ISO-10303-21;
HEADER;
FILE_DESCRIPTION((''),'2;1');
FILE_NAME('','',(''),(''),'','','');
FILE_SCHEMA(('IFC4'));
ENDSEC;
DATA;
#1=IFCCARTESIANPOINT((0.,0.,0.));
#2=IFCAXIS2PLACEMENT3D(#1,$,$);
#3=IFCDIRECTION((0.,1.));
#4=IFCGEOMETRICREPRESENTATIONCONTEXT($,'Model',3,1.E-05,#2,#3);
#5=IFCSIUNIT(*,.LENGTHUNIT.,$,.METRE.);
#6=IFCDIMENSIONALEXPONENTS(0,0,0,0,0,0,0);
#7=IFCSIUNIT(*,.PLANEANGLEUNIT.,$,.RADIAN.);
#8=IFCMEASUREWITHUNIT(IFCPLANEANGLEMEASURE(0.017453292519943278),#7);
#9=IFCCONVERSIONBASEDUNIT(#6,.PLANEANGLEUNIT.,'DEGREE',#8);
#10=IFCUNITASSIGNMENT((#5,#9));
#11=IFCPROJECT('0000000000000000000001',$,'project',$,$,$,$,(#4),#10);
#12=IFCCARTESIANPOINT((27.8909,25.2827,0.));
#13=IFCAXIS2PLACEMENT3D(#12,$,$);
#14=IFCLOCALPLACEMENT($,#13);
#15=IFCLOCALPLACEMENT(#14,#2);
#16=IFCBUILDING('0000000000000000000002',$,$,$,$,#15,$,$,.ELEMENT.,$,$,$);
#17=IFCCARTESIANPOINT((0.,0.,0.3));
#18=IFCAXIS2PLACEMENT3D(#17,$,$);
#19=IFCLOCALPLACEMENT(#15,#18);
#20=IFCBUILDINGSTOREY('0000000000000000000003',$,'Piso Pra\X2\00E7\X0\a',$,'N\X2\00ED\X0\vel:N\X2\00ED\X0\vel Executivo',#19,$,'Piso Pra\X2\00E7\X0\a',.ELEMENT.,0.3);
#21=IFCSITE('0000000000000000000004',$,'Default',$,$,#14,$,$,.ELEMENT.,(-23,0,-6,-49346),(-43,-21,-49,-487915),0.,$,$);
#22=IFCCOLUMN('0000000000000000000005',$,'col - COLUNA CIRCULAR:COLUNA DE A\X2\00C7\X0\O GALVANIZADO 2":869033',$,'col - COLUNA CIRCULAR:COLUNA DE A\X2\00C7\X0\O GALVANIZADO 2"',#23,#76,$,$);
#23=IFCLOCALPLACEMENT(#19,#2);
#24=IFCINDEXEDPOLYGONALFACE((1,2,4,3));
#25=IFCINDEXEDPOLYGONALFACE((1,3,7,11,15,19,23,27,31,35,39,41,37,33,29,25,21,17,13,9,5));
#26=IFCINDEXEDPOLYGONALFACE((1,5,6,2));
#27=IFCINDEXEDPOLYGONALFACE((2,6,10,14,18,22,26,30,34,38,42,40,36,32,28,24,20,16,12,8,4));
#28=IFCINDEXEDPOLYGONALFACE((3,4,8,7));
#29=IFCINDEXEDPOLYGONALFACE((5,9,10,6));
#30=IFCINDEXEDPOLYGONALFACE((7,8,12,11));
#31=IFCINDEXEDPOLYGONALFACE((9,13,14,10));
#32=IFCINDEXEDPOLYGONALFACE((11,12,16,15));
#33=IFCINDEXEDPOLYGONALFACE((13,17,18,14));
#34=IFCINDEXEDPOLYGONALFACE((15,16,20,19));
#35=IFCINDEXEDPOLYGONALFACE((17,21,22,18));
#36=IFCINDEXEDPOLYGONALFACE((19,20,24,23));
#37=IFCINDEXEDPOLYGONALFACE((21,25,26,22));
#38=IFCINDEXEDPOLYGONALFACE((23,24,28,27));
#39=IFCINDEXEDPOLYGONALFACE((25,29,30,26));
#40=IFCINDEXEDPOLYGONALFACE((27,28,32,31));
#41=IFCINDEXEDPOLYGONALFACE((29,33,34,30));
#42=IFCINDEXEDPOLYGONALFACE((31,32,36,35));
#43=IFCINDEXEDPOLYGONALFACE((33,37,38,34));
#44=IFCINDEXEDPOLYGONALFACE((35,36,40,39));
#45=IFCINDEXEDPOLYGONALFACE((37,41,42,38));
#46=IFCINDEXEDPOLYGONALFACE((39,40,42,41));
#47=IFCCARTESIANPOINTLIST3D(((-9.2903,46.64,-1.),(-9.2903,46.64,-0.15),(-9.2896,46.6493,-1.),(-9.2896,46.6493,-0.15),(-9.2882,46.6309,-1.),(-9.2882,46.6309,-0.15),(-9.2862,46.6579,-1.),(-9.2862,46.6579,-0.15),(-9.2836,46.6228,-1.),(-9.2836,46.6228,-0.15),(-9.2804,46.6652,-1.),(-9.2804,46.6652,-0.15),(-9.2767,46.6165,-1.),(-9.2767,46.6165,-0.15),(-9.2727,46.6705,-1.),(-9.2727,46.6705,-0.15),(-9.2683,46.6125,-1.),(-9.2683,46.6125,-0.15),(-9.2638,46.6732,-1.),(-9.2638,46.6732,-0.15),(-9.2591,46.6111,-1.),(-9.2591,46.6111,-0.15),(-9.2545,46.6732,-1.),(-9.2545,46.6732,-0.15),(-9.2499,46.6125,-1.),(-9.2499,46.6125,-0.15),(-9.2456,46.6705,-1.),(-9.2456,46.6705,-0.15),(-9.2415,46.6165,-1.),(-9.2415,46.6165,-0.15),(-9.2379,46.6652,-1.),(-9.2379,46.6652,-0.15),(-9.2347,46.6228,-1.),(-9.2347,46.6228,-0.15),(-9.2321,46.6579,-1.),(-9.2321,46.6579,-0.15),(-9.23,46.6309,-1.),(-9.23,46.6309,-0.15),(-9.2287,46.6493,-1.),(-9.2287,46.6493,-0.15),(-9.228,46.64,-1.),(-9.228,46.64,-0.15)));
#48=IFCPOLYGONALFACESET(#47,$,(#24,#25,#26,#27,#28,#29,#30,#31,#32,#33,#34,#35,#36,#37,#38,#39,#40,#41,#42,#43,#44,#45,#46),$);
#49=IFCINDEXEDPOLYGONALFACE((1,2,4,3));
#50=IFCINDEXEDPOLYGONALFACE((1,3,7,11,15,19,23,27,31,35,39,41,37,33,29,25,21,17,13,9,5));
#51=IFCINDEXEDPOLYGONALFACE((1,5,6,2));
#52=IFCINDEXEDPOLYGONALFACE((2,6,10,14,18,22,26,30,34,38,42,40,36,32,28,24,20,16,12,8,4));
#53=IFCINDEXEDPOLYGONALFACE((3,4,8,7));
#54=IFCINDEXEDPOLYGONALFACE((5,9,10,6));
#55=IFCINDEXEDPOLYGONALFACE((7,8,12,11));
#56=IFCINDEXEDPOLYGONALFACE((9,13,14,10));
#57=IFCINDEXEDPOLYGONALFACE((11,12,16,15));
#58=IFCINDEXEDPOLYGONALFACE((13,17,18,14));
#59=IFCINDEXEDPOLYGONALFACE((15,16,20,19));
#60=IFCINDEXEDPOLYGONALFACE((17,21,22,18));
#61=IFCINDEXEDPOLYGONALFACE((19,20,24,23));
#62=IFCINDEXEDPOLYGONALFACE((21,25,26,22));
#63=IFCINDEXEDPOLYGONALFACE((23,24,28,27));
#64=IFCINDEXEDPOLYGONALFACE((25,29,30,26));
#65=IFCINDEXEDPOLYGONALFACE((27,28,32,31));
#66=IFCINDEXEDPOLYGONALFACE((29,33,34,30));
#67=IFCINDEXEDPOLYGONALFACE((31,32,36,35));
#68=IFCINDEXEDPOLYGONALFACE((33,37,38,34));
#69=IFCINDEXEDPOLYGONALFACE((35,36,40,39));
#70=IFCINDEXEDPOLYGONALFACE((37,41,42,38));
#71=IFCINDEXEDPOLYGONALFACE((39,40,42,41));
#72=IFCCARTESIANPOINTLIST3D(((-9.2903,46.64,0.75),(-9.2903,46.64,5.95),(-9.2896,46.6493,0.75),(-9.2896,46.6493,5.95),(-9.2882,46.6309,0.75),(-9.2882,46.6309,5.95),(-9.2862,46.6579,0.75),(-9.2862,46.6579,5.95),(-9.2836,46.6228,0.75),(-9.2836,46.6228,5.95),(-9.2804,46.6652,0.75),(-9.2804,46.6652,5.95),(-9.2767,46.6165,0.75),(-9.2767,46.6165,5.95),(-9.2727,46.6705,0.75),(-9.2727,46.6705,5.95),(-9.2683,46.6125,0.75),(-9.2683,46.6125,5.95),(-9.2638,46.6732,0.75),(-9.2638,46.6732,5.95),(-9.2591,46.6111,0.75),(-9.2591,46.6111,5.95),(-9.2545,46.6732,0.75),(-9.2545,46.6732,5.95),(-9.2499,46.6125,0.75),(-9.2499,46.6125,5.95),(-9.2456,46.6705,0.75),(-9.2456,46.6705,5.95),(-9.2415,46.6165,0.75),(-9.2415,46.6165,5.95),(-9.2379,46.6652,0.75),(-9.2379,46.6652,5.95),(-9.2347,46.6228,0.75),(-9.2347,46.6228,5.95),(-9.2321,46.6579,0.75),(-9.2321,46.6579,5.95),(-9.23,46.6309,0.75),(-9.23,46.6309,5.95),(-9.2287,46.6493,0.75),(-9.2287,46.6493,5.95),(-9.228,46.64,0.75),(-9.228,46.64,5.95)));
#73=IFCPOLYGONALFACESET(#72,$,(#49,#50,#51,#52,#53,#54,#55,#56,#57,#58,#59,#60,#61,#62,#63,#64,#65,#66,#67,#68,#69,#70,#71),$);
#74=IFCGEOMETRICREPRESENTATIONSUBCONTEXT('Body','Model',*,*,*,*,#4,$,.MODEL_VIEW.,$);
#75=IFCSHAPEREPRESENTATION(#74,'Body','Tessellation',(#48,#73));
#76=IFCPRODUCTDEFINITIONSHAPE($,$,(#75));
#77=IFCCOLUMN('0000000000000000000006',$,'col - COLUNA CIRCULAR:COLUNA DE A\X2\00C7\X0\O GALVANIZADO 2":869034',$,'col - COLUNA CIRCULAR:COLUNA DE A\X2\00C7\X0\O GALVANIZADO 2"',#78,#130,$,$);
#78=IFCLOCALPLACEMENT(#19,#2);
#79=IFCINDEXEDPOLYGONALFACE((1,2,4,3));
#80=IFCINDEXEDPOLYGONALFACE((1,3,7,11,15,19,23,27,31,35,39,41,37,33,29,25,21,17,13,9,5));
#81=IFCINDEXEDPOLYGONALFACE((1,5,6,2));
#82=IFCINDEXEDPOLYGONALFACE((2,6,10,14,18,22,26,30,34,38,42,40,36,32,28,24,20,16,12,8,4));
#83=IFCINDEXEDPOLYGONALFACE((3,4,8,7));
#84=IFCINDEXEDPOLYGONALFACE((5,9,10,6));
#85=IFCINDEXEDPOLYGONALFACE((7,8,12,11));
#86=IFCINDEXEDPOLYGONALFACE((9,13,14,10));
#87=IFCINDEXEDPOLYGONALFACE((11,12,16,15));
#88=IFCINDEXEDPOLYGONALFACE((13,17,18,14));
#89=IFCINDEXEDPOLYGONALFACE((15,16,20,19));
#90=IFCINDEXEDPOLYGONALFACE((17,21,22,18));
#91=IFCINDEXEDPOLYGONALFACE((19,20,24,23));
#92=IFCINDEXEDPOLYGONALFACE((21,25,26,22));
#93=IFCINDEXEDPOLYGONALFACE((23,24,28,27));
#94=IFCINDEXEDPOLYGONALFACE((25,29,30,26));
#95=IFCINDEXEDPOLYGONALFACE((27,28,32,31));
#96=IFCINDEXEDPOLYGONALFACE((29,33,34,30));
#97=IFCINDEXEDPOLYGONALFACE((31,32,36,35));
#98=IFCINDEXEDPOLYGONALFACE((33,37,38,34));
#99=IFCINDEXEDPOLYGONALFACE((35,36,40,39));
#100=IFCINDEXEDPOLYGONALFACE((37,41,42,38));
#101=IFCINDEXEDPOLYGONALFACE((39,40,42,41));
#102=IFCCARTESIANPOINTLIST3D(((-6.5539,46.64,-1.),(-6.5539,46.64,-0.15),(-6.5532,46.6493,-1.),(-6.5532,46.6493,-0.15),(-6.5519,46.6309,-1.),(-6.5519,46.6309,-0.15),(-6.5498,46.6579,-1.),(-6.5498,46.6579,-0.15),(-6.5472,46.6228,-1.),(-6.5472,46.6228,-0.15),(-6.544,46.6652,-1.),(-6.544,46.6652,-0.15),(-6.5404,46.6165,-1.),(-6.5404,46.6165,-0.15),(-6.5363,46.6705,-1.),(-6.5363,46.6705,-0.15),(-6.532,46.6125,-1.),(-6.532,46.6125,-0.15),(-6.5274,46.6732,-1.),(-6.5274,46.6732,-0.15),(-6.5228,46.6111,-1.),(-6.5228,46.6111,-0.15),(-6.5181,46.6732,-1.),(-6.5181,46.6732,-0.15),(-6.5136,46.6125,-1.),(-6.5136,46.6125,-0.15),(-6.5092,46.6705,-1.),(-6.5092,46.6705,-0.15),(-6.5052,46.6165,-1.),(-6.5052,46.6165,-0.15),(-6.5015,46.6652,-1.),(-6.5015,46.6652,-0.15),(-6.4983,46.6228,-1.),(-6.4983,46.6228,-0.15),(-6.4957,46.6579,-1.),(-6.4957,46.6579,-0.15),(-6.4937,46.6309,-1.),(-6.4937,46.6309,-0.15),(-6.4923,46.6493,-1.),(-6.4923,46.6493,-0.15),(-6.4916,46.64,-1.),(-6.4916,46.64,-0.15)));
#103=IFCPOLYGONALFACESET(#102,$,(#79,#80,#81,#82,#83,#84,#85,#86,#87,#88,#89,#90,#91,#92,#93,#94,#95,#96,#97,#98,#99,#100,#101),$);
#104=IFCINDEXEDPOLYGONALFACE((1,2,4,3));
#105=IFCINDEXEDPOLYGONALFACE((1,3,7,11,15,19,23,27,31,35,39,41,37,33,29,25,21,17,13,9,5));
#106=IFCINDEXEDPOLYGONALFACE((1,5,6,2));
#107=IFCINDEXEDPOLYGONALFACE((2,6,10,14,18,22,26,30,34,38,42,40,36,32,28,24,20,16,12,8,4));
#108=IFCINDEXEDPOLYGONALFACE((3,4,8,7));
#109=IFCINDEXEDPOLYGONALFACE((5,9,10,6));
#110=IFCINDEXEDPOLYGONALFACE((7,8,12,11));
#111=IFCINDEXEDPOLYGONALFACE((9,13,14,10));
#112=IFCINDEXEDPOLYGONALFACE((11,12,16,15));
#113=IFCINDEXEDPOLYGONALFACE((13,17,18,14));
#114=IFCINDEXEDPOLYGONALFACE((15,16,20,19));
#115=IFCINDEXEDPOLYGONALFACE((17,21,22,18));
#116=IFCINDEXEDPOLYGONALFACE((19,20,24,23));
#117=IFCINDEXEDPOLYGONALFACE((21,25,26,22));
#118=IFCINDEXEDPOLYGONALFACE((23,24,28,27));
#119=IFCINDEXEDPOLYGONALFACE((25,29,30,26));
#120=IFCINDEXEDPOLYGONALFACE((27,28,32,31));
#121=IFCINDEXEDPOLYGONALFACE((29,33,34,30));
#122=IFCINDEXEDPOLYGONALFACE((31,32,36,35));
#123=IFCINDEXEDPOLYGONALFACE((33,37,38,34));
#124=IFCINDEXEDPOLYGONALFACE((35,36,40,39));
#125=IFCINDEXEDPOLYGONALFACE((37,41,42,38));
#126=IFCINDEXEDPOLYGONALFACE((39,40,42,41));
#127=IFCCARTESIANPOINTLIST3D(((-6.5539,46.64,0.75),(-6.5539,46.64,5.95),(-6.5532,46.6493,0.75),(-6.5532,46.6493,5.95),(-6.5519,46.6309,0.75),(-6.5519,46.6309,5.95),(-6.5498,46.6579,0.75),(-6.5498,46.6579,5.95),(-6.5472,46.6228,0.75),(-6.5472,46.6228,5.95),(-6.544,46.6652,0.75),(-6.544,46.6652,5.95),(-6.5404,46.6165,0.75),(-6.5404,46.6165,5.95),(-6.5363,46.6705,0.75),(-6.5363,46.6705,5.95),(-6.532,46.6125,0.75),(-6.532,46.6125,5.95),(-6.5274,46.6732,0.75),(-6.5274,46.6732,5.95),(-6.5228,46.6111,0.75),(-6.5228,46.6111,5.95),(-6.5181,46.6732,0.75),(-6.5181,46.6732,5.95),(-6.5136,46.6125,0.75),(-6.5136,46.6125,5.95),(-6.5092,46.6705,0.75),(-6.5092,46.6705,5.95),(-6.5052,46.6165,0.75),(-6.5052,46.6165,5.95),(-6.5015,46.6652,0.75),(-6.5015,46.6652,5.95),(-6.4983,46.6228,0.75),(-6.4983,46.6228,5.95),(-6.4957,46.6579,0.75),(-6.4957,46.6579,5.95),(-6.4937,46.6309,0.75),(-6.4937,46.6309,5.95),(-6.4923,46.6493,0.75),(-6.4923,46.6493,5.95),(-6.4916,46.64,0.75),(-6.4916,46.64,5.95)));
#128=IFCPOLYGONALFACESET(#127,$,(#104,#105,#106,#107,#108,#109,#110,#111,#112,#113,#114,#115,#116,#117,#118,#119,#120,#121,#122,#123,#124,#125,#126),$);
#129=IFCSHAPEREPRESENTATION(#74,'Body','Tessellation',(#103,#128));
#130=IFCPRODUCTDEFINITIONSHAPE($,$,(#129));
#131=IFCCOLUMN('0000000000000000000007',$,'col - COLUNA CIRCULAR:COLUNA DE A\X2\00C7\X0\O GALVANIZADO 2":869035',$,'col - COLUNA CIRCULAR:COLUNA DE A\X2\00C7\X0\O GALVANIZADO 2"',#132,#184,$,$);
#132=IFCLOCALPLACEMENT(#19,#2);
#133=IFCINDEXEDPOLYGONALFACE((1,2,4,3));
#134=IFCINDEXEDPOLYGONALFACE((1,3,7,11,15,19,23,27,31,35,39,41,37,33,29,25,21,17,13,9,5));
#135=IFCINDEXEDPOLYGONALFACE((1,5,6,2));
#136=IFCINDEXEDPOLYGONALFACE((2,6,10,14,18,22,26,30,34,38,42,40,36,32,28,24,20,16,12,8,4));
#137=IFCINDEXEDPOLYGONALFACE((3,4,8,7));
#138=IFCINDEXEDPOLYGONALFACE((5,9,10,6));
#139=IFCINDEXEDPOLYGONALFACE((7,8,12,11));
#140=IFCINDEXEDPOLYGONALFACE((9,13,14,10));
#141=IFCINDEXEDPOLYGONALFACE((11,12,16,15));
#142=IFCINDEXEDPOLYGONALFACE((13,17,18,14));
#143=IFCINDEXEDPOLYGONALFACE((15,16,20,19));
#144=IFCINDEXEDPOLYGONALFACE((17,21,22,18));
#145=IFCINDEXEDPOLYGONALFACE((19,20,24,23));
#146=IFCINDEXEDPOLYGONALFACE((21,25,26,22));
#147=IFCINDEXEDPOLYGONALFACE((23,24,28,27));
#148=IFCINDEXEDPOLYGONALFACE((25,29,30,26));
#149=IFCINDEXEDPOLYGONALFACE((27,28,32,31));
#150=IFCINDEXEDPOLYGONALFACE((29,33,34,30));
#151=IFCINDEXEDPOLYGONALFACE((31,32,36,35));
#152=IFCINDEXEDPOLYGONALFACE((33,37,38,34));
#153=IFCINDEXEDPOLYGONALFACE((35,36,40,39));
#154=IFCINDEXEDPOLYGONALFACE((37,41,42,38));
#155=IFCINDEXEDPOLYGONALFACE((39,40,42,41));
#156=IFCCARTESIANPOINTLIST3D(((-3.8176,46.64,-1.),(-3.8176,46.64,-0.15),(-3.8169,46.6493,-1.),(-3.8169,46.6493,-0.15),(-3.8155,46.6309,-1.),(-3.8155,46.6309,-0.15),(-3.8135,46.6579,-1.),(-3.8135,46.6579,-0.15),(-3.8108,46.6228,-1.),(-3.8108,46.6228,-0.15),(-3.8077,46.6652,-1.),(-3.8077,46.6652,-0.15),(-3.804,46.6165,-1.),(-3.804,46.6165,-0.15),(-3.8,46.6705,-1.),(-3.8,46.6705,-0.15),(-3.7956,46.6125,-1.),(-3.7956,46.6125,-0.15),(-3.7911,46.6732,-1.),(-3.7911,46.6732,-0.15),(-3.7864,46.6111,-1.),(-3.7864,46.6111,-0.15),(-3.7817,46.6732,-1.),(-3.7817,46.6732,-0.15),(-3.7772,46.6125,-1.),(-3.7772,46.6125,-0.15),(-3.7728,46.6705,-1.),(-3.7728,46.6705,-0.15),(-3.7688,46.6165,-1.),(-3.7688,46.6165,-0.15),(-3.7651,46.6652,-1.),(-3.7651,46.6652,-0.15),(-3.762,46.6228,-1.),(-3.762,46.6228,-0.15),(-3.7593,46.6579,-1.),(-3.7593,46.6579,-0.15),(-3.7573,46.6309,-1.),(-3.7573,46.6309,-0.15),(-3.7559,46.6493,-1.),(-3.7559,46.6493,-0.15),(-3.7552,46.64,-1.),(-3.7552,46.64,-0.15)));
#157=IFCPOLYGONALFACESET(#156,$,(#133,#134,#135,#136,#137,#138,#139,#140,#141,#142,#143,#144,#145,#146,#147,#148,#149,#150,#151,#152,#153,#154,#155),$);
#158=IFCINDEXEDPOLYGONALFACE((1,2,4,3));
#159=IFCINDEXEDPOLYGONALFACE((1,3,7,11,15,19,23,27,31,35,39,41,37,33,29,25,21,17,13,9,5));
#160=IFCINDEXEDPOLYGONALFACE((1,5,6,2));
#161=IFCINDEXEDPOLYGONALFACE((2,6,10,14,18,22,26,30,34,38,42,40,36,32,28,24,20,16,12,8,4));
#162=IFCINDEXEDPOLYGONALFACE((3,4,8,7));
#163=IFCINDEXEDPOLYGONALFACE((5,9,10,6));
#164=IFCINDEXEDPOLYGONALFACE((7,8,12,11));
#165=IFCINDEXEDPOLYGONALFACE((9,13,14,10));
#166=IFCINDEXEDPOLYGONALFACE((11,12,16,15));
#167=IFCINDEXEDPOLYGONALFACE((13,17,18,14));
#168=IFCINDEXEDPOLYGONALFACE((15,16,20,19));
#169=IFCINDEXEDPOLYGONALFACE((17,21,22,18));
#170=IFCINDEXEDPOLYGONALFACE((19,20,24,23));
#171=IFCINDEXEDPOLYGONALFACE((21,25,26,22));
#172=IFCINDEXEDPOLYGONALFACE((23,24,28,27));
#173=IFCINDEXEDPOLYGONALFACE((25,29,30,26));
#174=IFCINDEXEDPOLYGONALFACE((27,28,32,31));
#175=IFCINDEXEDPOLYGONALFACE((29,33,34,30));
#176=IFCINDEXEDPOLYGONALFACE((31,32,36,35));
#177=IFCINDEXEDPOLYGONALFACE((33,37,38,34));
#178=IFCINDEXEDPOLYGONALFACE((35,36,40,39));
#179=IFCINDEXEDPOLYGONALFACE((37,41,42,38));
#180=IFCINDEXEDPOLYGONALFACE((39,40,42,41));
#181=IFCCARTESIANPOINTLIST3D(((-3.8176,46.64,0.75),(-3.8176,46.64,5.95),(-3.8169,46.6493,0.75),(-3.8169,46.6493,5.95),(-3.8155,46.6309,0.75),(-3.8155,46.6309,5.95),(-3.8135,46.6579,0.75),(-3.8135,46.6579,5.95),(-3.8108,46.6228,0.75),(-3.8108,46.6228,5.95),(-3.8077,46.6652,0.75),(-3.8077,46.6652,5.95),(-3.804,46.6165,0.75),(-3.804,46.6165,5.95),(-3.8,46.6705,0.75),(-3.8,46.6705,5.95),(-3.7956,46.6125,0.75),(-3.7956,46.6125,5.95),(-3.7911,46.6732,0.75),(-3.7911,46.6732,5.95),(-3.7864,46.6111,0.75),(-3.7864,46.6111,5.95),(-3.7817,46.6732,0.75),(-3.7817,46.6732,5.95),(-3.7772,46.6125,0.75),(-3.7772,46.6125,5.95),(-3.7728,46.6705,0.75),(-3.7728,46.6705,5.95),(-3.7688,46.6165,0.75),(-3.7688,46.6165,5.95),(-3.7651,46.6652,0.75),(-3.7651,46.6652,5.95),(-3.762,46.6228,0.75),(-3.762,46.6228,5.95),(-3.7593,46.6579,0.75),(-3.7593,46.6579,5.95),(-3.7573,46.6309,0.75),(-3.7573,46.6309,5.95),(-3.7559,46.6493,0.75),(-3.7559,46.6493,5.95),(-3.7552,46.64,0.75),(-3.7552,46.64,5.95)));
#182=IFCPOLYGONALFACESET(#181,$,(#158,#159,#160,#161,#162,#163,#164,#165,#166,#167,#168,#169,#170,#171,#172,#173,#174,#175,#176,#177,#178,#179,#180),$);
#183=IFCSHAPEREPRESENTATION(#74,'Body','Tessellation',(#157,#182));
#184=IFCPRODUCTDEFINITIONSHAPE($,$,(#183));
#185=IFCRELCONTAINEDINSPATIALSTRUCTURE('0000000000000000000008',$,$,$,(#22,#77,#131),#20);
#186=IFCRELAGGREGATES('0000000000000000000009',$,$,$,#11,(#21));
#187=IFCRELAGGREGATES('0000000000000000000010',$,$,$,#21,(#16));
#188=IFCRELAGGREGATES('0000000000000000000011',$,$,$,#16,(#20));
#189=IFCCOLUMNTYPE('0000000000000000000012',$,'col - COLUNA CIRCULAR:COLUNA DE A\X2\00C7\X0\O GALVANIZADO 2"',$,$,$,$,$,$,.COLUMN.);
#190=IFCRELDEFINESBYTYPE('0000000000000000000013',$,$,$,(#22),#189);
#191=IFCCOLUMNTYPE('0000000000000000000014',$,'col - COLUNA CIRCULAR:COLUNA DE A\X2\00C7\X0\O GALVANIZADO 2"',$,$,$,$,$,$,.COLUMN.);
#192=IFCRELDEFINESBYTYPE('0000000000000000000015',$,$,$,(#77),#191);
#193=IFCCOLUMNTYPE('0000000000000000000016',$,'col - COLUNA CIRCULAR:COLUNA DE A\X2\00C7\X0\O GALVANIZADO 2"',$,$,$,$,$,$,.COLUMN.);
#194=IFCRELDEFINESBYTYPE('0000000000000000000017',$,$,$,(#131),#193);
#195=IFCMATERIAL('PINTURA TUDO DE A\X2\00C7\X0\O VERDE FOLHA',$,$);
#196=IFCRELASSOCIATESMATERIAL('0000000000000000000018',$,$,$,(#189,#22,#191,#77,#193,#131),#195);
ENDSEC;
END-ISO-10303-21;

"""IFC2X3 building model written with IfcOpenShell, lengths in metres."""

from ifc_helpers import new_model, entity, si_unit, converted_unit, direction, frame, origin, origin_2d_with_axis, place, context, subcontext, project, spatial, circle, extrude, source, transform, mapped, material, type_object, type_shapes, element, save


model = new_model("IFC2X3")

# Units and contexts
model_context = context("Model", 3, precision=1e-05, world=origin(), true_north=direction((0.0, 1.0)))
body_context = subcontext(model_context, "Body", "Model", "MODEL_VIEW")
ifc_project = project(units=[si_unit("LENGTHUNIT", "METRE"), converted_unit("PLANEANGLEUNIT", "DEGREE", entity("IfcPlaneAngleMeasure", 0.017453292519943278), si_unit("PLANEANGLEUNIT", "RADIAN"), dimensions=[0, 0, 0, 0, 0, 0, 0])], contexts=[model_context])

# Site, building, storey
site_placement = place(None, frame((27.8909, 25.2827, 0.0)))
site = spatial("IfcSite", under=ifc_project, at=site_placement, Name="Default", CompositionType="ELEMENT", RefLatitude=(-23, 0, -6, -49346), RefLongitude=(-43, -21, -49, -487915), RefElevation=0.0)
building_placement = place(site_placement, origin())
building = spatial("IfcBuilding", under=site, at=building_placement, CompositionType="ELEMENT")
storey_placement = place(building_placement, frame((0.0, 0.0, 0.3)))
storey = spatial("IfcBuildingStorey", under=building, at=storey_placement, Name="Piso Praça", ObjectType="Nível:Nível Executivo", LongName="Piso Praça", CompositionType="ELEMENT", Elevation=0.3)

# Columns
ifc_material = material(Name="PINTURA TUDO DE AÇO VERDE FOLHA")
column_type_1 = type_object("IfcColumnType", Name="col - COLUNA CIRCULAR:COLUNA DE AÇO GALVANIZADO 2\"", PredefinedType="COLUMN", material=ifc_material)
shared_shape_1 = source(origin(), body_context, "Body", "SweptSolid", [
    extrude(circle(Radius=0.0312, at=origin_2d_with_axis()), frame((-9.2591, 46.6423, -0.7), z_axis=(0.0, 0.0, 1.0), x_axis=(0.0, -1.0, 0.0)), (0.0, 0.0, 1.0), 0.85),
    extrude(circle(Radius=0.0312, at=origin_2d_with_axis()), frame((-9.2591, 46.6423, 1.05), z_axis=(0.0, 0.0, 1.0), x_axis=(0.0, -1.0, 0.0)), (0.0, 0.0, 1.0), 5.2),
])
type_shapes(column_type_1, [shared_shape_1])
column_1_placement = place(storey_placement, frame((0.0, 0.0, -0.3)))
element("IfcColumn", 1, at=column_1_placement, inside=storey, type_object=column_type_1, material=ifc_material, Name="col - COLUNA CIRCULAR:COLUNA DE AÇO GALVANIZADO 2\":869033", ObjectType="col - COLUNA CIRCULAR:COLUNA DE AÇO GALVANIZADO 2\"", context=body_context, shape_type="MappedRepresentation", body=[
    mapped(shared_shape_1, transform((0.0, 0.0, 0.0), scale=1.0)),
])
column_type_2 = type_object("IfcColumnType", Name="col - COLUNA CIRCULAR:COLUNA DE AÇO GALVANIZADO 2\"", PredefinedType="COLUMN", material=ifc_material)
shared_shape_2 = source(origin(), body_context, "Body", "SweptSolid", [
    extrude(circle(Radius=0.0312, at=origin_2d_with_axis()), frame((-6.5228, 46.6423, -0.7), z_axis=(0.0, 0.0, 1.0), x_axis=(0.0, -1.0, 0.0)), (0.0, 0.0, 1.0), 0.85),
    extrude(circle(Radius=0.0312, at=origin_2d_with_axis()), frame((-6.5228, 46.6423, 1.05), z_axis=(0.0, 0.0, 1.0), x_axis=(0.0, -1.0, 0.0)), (0.0, 0.0, 1.0), 5.2),
])
type_shapes(column_type_2, [shared_shape_2])
column_2_placement = place(storey_placement, frame((0.0, 0.0, -0.3)))
element("IfcColumn", 2, at=column_2_placement, inside=storey, type_object=column_type_2, material=ifc_material, Name="col - COLUNA CIRCULAR:COLUNA DE AÇO GALVANIZADO 2\":869034", ObjectType="col - COLUNA CIRCULAR:COLUNA DE AÇO GALVANIZADO 2\"", context=body_context, shape_type="MappedRepresentation", body=[
    mapped(shared_shape_2, transform((0.0, 0.0, 0.0), scale=1.0)),
])
column_type_3 = type_object("IfcColumnType", Name="col - COLUNA CIRCULAR:COLUNA DE AÇO GALVANIZADO 2\"", PredefinedType="COLUMN", material=ifc_material)
shared_shape_3 = source(origin(), body_context, "Body", "SweptSolid", [
    extrude(circle(Radius=0.0312, at=origin_2d_with_axis()), frame((-3.7864, 46.6423, -0.7), z_axis=(0.0, 0.0, 1.0), x_axis=(0.0, -1.0, 0.0)), (0.0, 0.0, 1.0), 0.85),
    extrude(circle(Radius=0.0312, at=origin_2d_with_axis()), frame((-3.7864, 46.6423, 1.05), z_axis=(0.0, 0.0, 1.0), x_axis=(0.0, -1.0, 0.0)), (0.0, 0.0, 1.0), 5.2),
])
type_shapes(column_type_3, [shared_shape_3])
column_3_placement = place(storey_placement, frame((0.0, 0.0, -0.3)))
element("IfcColumn", 3, at=column_3_placement, inside=storey, type_object=column_type_3, material=ifc_material, Name="col - COLUNA CIRCULAR:COLUNA DE AÇO GALVANIZADO 2\":869035", ObjectType="col - COLUNA CIRCULAR:COLUNA DE AÇO GALVANIZADO 2\"", context=body_context, shape_type="MappedRepresentation", body=[
    mapped(shared_shape_3, transform((0.0, 0.0, 0.0), scale=1.0)),
])

save(model, "model.ifc")
